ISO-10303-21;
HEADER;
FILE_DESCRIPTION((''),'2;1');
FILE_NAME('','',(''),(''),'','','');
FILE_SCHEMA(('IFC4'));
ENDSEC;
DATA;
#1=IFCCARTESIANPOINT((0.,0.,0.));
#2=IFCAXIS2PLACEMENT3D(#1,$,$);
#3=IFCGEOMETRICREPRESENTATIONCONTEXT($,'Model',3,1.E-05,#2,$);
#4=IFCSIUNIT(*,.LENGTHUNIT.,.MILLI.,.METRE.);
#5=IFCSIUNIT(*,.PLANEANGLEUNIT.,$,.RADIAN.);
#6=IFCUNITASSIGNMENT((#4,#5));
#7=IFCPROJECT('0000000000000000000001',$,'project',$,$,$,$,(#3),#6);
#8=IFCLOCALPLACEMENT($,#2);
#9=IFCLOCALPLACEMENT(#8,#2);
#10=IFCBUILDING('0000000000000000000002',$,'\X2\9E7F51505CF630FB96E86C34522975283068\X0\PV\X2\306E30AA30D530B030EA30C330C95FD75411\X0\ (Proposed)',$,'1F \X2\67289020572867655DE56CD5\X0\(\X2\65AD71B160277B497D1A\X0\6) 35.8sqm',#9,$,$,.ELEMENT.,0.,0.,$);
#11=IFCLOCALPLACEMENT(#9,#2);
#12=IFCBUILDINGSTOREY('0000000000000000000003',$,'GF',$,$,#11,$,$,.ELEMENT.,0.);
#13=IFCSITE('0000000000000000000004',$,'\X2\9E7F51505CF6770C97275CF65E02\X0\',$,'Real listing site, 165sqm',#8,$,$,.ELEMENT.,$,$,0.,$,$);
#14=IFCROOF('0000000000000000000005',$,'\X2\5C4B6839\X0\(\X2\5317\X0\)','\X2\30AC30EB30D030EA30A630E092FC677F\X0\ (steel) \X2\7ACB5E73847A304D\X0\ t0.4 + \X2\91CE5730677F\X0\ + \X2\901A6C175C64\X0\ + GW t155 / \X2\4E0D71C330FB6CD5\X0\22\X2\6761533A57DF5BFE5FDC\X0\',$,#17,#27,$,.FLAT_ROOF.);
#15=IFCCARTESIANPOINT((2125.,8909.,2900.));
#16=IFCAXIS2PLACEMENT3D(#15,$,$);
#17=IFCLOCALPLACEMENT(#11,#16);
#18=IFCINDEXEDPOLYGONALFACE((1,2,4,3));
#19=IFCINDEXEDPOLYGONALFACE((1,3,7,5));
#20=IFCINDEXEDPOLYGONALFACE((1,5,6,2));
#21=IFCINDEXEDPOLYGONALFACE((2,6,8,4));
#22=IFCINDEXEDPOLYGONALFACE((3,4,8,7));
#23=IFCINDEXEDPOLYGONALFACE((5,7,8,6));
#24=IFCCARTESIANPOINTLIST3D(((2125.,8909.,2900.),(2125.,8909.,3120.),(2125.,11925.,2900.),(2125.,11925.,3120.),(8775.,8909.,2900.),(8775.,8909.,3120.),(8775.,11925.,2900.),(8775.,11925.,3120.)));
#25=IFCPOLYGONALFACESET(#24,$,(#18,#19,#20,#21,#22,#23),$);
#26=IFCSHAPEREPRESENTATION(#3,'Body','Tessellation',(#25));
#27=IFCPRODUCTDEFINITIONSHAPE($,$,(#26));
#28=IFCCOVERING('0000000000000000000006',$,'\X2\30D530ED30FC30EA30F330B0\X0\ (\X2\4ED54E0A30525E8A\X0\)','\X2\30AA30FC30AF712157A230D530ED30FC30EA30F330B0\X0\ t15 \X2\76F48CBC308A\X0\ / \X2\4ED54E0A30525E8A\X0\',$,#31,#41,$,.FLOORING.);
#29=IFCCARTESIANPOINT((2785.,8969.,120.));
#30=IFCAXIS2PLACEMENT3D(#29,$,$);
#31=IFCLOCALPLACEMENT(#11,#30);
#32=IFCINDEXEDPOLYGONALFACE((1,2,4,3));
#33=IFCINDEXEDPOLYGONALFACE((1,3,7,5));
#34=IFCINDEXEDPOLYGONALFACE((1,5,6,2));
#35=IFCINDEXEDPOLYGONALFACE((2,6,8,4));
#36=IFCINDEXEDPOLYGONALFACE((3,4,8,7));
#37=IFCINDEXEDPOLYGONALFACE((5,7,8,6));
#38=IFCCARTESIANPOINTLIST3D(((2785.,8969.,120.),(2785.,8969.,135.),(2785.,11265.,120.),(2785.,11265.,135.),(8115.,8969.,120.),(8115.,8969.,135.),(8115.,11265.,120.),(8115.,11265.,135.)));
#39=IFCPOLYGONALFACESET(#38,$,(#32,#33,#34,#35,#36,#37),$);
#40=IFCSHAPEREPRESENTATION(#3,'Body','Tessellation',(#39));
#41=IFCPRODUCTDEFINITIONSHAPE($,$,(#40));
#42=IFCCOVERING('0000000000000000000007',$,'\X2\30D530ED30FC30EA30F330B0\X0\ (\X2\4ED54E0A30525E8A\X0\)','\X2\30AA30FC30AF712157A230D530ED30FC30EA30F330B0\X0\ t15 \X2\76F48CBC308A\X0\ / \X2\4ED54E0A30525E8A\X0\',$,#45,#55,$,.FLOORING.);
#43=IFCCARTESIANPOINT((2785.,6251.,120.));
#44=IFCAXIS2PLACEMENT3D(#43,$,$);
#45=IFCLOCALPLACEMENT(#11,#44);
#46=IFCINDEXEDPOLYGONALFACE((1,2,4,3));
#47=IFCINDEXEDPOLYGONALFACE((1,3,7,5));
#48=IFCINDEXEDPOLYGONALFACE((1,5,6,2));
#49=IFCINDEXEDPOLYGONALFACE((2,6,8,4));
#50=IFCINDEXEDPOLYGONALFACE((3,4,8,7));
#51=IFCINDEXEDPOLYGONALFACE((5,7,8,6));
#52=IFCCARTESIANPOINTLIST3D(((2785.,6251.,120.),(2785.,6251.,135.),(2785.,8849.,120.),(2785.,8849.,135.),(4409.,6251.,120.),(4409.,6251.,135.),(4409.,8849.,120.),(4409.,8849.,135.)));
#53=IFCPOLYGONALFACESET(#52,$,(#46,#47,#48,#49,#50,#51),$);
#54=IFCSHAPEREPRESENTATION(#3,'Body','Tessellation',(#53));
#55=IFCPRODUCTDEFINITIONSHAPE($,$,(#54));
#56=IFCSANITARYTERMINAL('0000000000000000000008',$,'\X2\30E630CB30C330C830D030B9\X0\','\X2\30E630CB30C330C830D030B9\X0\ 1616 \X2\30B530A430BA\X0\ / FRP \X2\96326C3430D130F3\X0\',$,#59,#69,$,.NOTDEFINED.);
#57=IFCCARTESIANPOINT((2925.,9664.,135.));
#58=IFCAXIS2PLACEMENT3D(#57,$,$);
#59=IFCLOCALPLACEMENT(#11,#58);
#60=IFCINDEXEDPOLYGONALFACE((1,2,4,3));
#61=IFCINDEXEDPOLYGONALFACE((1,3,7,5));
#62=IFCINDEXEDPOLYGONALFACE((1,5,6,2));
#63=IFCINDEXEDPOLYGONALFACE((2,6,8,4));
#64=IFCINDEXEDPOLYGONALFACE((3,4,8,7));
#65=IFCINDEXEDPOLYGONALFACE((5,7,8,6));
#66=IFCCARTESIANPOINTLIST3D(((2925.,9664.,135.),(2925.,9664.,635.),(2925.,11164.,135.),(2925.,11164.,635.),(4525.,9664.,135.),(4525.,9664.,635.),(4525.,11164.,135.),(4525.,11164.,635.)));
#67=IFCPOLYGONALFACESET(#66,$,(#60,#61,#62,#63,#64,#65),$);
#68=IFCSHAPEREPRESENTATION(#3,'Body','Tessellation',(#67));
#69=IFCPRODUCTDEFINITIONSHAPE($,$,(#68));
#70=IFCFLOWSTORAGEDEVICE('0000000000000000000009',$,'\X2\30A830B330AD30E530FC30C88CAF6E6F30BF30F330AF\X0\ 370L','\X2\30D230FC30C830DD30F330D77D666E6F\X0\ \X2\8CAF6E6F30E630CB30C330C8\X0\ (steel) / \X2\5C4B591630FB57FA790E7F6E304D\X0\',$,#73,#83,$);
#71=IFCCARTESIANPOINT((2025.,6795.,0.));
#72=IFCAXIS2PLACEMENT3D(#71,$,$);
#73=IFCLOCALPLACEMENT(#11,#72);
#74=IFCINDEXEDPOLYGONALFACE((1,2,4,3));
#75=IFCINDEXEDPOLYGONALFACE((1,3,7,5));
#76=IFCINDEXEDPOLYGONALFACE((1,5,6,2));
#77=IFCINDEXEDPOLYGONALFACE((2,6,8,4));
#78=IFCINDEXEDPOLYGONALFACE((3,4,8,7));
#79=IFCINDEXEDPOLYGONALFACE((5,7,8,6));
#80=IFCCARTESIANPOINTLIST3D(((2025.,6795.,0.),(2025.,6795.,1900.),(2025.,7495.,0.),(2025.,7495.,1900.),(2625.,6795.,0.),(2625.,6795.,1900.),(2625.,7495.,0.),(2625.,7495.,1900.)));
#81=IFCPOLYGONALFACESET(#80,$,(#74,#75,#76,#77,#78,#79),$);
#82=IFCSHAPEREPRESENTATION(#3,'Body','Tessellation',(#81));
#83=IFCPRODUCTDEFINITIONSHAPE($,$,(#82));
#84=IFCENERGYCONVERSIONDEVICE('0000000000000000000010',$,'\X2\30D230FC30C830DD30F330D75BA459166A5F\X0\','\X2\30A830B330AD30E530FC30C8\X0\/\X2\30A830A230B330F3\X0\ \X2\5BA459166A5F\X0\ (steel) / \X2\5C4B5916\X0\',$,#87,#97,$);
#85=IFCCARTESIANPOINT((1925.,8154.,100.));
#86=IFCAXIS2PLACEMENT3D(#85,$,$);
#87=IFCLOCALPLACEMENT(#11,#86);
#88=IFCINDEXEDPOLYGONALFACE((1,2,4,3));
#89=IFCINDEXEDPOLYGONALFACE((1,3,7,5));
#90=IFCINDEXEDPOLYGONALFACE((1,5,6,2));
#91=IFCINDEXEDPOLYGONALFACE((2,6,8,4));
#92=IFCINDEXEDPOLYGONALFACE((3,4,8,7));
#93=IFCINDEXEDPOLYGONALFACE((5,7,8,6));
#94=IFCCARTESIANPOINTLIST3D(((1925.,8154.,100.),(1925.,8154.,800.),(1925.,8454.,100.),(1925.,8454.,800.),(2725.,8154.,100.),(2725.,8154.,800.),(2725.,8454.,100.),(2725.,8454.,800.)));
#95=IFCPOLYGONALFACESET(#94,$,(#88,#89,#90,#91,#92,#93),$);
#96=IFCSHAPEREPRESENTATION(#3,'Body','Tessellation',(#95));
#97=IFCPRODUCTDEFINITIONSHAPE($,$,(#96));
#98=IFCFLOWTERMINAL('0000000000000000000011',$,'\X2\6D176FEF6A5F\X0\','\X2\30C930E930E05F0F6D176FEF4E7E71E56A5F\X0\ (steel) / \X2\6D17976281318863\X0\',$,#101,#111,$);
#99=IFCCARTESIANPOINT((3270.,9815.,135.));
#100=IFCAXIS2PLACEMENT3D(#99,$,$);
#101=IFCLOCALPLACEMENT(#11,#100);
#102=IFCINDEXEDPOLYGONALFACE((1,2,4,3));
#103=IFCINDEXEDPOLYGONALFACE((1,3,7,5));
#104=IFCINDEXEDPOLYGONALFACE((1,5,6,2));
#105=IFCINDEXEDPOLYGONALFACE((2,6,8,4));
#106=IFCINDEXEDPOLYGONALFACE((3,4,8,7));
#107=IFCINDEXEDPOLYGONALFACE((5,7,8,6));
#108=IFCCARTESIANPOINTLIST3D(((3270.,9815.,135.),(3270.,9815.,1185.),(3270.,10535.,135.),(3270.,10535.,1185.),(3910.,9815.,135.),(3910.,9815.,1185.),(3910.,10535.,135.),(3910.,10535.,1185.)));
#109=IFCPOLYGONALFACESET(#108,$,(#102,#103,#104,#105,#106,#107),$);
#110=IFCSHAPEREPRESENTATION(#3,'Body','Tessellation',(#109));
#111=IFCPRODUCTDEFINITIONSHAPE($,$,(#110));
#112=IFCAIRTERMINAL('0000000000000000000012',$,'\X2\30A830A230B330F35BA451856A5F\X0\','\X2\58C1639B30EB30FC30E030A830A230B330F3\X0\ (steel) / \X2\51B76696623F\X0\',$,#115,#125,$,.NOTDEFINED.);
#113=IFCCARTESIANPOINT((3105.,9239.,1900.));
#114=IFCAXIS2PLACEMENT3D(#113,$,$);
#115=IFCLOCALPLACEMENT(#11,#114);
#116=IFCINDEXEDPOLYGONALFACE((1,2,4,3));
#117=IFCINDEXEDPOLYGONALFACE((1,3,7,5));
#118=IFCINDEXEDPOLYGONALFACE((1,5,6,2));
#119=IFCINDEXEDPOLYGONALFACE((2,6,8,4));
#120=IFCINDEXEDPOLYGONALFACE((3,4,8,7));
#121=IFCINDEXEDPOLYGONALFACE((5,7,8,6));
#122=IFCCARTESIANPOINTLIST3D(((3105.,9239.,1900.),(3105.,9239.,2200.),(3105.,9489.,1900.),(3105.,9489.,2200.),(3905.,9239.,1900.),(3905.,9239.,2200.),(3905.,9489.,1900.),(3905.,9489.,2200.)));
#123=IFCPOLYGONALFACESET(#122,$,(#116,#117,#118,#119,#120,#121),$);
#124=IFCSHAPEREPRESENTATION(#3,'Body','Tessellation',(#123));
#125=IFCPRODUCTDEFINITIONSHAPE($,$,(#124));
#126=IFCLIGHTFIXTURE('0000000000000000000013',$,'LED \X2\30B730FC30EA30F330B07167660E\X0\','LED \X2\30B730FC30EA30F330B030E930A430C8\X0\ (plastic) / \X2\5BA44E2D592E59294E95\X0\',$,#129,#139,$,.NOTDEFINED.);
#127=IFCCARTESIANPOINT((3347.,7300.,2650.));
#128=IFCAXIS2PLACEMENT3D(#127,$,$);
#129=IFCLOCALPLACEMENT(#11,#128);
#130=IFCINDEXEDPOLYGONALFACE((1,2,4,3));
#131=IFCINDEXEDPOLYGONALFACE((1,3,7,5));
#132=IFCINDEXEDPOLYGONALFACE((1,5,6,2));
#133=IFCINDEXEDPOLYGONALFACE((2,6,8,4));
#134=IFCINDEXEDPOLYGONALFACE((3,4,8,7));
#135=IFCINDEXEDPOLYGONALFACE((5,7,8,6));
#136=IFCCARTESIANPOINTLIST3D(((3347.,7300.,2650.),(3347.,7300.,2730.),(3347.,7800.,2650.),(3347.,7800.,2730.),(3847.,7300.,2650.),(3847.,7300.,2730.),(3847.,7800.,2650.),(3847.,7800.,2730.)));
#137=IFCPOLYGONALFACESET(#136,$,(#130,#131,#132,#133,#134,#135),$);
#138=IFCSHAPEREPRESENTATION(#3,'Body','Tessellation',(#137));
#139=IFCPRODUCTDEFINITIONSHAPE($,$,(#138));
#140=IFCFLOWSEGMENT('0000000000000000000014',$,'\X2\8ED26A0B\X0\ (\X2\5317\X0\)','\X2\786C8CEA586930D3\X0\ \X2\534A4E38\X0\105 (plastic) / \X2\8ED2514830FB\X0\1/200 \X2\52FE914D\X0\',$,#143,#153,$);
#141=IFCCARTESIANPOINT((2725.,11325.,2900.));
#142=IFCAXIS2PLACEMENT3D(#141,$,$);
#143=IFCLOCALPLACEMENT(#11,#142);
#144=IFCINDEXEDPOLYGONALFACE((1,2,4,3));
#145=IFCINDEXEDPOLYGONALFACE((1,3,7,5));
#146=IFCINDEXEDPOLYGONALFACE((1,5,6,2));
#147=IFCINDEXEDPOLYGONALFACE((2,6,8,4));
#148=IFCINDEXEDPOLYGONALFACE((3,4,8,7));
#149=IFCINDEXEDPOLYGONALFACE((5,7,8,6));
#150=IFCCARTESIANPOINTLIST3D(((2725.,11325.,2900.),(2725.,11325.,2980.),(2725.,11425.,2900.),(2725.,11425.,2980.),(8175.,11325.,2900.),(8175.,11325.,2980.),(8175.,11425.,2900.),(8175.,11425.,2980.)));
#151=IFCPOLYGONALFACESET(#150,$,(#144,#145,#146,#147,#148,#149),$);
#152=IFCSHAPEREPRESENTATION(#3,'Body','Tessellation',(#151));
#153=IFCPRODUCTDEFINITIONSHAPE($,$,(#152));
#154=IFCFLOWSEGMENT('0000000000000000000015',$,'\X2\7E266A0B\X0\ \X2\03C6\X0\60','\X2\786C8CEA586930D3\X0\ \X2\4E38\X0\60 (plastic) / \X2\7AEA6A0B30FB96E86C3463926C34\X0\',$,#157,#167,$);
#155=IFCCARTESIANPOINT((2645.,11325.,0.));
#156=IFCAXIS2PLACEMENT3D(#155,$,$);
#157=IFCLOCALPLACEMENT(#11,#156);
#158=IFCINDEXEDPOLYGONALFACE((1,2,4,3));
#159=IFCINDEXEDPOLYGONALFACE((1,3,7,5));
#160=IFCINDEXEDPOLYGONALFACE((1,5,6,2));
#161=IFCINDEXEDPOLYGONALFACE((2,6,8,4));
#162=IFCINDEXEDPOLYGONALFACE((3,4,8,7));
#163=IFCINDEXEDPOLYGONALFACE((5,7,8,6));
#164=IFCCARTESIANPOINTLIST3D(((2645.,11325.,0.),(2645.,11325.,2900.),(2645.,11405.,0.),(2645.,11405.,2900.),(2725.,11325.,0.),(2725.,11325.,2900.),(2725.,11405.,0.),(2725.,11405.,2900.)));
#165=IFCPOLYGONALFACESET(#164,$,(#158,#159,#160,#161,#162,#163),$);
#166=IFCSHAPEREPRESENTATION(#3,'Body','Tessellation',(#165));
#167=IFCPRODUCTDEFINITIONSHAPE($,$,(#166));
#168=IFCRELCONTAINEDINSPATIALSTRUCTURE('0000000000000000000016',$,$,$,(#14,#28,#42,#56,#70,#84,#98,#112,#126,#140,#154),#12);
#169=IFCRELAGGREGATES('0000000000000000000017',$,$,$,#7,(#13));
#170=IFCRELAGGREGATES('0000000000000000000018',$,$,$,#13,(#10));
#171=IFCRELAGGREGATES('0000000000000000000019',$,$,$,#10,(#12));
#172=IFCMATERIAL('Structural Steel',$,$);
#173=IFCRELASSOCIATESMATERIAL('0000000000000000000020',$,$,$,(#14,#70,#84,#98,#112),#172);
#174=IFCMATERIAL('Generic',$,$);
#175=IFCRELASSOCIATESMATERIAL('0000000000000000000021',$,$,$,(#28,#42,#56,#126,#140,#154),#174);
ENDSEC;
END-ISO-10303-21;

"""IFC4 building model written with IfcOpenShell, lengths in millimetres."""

from ifc_helpers import new_model, si_unit, frame, frame_2d, origin, place, context, project, spatial, rectangle, extrude, material, element, save


model = new_model("IFC4")

# Units and contexts
model_context = context("Model", 3, precision=1e-05, world=origin())
ifc_project = project(units=[si_unit("LENGTHUNIT", "METRE", prefix="MILLI"), si_unit("PLANEANGLEUNIT", "RADIAN")], contexts=[model_context])

# Site, building, storey
site_placement = place(None, origin())
site = spatial("IfcSite", under=ifc_project, at=site_placement, Name="鹿児島県霧島市", ObjectType="Real listing site, 165sqm", CompositionType="ELEMENT", RefElevation=0.0)
building_placement = place(site_placement, origin())
building = spatial("IfcBuilding", under=site, at=building_placement, Name="鹿児島・雨水利用とPVのオフグリッド志向 (Proposed)", ObjectType="1F 木造在来工法(断熱性等級6) 35.8sqm", CompositionType="ELEMENT", ElevationOfRefHeight=0.0, ElevationOfTerrain=0.0)
storey_placement = place(building_placement, origin())
storey = spatial("IfcBuildingStorey", under=building, at=storey_placement, Name="GF", CompositionType="ELEMENT", Elevation=0.0)

# Roof
ifc_material_1 = material(Name="Structural Steel")
roof_placement = place(storey_placement, frame((2125.0, 8909.0, 2900.0)))
element("IfcRoof", 1, at=roof_placement, inside=storey, material=ifc_material_1, Name="屋根(北)", Description="ガルバリウム鋼板 (steel) 立平葺き t0.4 + 野地板 + 通気層 + GW t155 / 不燃・法22条区域対応", PredefinedType="FLAT_ROOF", context=model_context, shape_type="SweptSolid", body=[
    extrude(rectangle(XDim=6650.0, YDim=3016.0, at=frame_2d((3325.0, 1508.0))), frame((2125.0, 8909.0, 2900.0)), (0.0, 0.0, 1.0), 220.0),
])

# Coverings
ifc_material_2 = material(Name="Generic")
covering_1_placement = place(storey_placement, frame((2785.0, 8969.0, 120.0)))
element("IfcCovering", 2, at=covering_1_placement, inside=storey, material=ifc_material_2, Name="フローリング (仕上げ床)", Description="オーク無垢フローリング t15 直貼り / 仕上げ床", PredefinedType="FLOORING", context=model_context, shape_type="SweptSolid", body=[
    extrude(rectangle(XDim=5330.0, YDim=2296.0, at=frame_2d((2665.0, 1148.0))), frame((2785.0, 8969.0, 120.0)), (0.0, 0.0, 1.0), 15.0),
])
covering_2_placement = place(storey_placement, frame((2785.0, 6251.0, 120.0)))
element("IfcCovering", 3, at=covering_2_placement, inside=storey, material=ifc_material_2, Name="フローリング (仕上げ床)", Description="オーク無垢フローリング t15 直貼り / 仕上げ床", PredefinedType="FLOORING", context=model_context, shape_type="SweptSolid", body=[
    extrude(rectangle(XDim=1624.0, YDim=2598.0, at=frame_2d((812.0, 1299.0))), frame((2785.0, 6251.0, 120.0)), (0.0, 0.0, 1.0), 15.0),
])

# Sanitary terminal
sanitary_terminal_placement = place(storey_placement, frame((2925.0, 9664.0, 135.0)))
element("IfcSanitaryTerminal", 4, at=sanitary_terminal_placement, inside=storey, material=ifc_material_2, Name="ユニットバス", Description="ユニットバス 1616 サイズ / FRP 防水パン", PredefinedType="NOTDEFINED", context=model_context, shape_type="SweptSolid", body=[
    extrude(rectangle(XDim=1600.0, YDim=1500.0, at=frame_2d((800.0, 750.0))), frame((2925.0, 9664.0, 135.0)), (0.0, 0.0, 1.0), 500.0),
])

# Flow storage device
flow_storage_device_placement = place(storey_placement, frame((2025.0, 6795.0, 0.0)))
element("IfcFlowStorageDevice", 5, at=flow_storage_device_placement, inside=storey, material=ifc_material_1, Name="エコキュート貯湯タンク 370L", Description="ヒートポンプ給湯 貯湯ユニット (steel) / 屋外・基礎置き", context=model_context, shape_type="SweptSolid", body=[
    extrude(rectangle(XDim=600.0, YDim=700.0, at=frame_2d((300.0, 350.0))), frame((2025.0, 6795.0, 0.0)), (0.0, 0.0, 1.0), 1900.0),
])

# Energy conversion device
energy_conversion_device_placement = place(storey_placement, frame((1925.0, 8154.0, 100.0)))
element("IfcEnergyConversionDevice", 6, at=energy_conversion_device_placement, inside=storey, material=ifc_material_1, Name="ヒートポンプ室外機", Description="エコキュート/エアコン 室外機 (steel) / 屋外", context=model_context, shape_type="SweptSolid", body=[
    extrude(rectangle(XDim=800.0, YDim=300.0, at=frame_2d((400.0, 150.0))), frame((1925.0, 8154.0, 100.0)), (0.0, 0.0, 1.0), 700.0),
])

# Flow terminal
flow_terminal_placement = place(storey_placement, frame((3270.0, 9815.0, 135.0)))
element("IfcFlowTerminal", 7, at=flow_terminal_placement, inside=storey, material=ifc_material_1, Name="洗濯機", Description="ドラム式洗濯乾燥機 (steel) / 洗面脱衣", context=model_context, shape_type="SweptSolid", body=[
    extrude(rectangle(XDim=640.0, YDim=720.0, at=frame_2d((320.0, 360.0))), frame((3270.0, 9815.0, 135.0)), (0.0, 0.0, 1.0), 1050.0),
])

# Air terminal
air_terminal_placement = place(storey_placement, frame((3105.0, 9239.0, 1900.0)))
element("IfcAirTerminal", 8, at=air_terminal_placement, inside=storey, material=ifc_material_1, Name="エアコン室内機", Description="壁掛ルームエアコン (steel) / 冷暖房", PredefinedType="NOTDEFINED", context=model_context, shape_type="SweptSolid", body=[
    extrude(rectangle(XDim=800.0, YDim=250.0, at=frame_2d((400.0, 125.0))), frame((3105.0, 9239.0, 1900.0)), (0.0, 0.0, 1.0), 300.0),
])

# Light fixture
light_fixture_placement = place(storey_placement, frame((3347.0, 7300.0, 2650.0)))
element("IfcLightFixture", 9, at=light_fixture_placement, inside=storey, material=ifc_material_2, Name="LED シーリング照明", Description="LED シーリングライト (plastic) / 室中央天井", PredefinedType="NOTDEFINED", context=model_context, shape_type="SweptSolid", body=[
    extrude(rectangle(XDim=500.0, YDim=500.0, at=frame_2d((250.0, 250.0))), frame((3347.0, 7300.0, 2650.0)), (0.0, 0.0, 1.0), 80.0),
])

# Flow segments
flow_segment_1_placement = place(storey_placement, frame((2725.0, 11325.0, 2900.0)))
element("IfcFlowSegment", 10, at=flow_segment_1_placement, inside=storey, material=ifc_material_2, Name="軒樋 (北)", Description="硬質塩ビ 半丸105 (plastic) / 軒先・1/200 勾配", context=model_context, shape_type="SweptSolid", body=[
    extrude(rectangle(XDim=5450.0, YDim=100.0, at=frame_2d((2725.0, 50.0))), frame((2725.0, 11325.0, 2900.0)), (0.0, 0.0, 1.0), 80.0),
])
flow_segment_2_placement = place(storey_placement, frame((2645.0, 11325.0, 0.0)))
element("IfcFlowSegment", 11, at=flow_segment_2_placement, inside=storey, material=ifc_material_2, Name="縦樋 φ60", Description="硬質塩ビ 丸60 (plastic) / 竪樋・雨水排水", context=model_context, shape_type="SweptSolid", body=[
    extrude(rectangle(XDim=80.0, YDim=80.0, at=frame_2d((40.0, 40.0))), frame((2645.0, 11325.0, 0.0)), (0.0, 0.0, 1.0), 2900.0),
])

save(model, "model.ifc")
